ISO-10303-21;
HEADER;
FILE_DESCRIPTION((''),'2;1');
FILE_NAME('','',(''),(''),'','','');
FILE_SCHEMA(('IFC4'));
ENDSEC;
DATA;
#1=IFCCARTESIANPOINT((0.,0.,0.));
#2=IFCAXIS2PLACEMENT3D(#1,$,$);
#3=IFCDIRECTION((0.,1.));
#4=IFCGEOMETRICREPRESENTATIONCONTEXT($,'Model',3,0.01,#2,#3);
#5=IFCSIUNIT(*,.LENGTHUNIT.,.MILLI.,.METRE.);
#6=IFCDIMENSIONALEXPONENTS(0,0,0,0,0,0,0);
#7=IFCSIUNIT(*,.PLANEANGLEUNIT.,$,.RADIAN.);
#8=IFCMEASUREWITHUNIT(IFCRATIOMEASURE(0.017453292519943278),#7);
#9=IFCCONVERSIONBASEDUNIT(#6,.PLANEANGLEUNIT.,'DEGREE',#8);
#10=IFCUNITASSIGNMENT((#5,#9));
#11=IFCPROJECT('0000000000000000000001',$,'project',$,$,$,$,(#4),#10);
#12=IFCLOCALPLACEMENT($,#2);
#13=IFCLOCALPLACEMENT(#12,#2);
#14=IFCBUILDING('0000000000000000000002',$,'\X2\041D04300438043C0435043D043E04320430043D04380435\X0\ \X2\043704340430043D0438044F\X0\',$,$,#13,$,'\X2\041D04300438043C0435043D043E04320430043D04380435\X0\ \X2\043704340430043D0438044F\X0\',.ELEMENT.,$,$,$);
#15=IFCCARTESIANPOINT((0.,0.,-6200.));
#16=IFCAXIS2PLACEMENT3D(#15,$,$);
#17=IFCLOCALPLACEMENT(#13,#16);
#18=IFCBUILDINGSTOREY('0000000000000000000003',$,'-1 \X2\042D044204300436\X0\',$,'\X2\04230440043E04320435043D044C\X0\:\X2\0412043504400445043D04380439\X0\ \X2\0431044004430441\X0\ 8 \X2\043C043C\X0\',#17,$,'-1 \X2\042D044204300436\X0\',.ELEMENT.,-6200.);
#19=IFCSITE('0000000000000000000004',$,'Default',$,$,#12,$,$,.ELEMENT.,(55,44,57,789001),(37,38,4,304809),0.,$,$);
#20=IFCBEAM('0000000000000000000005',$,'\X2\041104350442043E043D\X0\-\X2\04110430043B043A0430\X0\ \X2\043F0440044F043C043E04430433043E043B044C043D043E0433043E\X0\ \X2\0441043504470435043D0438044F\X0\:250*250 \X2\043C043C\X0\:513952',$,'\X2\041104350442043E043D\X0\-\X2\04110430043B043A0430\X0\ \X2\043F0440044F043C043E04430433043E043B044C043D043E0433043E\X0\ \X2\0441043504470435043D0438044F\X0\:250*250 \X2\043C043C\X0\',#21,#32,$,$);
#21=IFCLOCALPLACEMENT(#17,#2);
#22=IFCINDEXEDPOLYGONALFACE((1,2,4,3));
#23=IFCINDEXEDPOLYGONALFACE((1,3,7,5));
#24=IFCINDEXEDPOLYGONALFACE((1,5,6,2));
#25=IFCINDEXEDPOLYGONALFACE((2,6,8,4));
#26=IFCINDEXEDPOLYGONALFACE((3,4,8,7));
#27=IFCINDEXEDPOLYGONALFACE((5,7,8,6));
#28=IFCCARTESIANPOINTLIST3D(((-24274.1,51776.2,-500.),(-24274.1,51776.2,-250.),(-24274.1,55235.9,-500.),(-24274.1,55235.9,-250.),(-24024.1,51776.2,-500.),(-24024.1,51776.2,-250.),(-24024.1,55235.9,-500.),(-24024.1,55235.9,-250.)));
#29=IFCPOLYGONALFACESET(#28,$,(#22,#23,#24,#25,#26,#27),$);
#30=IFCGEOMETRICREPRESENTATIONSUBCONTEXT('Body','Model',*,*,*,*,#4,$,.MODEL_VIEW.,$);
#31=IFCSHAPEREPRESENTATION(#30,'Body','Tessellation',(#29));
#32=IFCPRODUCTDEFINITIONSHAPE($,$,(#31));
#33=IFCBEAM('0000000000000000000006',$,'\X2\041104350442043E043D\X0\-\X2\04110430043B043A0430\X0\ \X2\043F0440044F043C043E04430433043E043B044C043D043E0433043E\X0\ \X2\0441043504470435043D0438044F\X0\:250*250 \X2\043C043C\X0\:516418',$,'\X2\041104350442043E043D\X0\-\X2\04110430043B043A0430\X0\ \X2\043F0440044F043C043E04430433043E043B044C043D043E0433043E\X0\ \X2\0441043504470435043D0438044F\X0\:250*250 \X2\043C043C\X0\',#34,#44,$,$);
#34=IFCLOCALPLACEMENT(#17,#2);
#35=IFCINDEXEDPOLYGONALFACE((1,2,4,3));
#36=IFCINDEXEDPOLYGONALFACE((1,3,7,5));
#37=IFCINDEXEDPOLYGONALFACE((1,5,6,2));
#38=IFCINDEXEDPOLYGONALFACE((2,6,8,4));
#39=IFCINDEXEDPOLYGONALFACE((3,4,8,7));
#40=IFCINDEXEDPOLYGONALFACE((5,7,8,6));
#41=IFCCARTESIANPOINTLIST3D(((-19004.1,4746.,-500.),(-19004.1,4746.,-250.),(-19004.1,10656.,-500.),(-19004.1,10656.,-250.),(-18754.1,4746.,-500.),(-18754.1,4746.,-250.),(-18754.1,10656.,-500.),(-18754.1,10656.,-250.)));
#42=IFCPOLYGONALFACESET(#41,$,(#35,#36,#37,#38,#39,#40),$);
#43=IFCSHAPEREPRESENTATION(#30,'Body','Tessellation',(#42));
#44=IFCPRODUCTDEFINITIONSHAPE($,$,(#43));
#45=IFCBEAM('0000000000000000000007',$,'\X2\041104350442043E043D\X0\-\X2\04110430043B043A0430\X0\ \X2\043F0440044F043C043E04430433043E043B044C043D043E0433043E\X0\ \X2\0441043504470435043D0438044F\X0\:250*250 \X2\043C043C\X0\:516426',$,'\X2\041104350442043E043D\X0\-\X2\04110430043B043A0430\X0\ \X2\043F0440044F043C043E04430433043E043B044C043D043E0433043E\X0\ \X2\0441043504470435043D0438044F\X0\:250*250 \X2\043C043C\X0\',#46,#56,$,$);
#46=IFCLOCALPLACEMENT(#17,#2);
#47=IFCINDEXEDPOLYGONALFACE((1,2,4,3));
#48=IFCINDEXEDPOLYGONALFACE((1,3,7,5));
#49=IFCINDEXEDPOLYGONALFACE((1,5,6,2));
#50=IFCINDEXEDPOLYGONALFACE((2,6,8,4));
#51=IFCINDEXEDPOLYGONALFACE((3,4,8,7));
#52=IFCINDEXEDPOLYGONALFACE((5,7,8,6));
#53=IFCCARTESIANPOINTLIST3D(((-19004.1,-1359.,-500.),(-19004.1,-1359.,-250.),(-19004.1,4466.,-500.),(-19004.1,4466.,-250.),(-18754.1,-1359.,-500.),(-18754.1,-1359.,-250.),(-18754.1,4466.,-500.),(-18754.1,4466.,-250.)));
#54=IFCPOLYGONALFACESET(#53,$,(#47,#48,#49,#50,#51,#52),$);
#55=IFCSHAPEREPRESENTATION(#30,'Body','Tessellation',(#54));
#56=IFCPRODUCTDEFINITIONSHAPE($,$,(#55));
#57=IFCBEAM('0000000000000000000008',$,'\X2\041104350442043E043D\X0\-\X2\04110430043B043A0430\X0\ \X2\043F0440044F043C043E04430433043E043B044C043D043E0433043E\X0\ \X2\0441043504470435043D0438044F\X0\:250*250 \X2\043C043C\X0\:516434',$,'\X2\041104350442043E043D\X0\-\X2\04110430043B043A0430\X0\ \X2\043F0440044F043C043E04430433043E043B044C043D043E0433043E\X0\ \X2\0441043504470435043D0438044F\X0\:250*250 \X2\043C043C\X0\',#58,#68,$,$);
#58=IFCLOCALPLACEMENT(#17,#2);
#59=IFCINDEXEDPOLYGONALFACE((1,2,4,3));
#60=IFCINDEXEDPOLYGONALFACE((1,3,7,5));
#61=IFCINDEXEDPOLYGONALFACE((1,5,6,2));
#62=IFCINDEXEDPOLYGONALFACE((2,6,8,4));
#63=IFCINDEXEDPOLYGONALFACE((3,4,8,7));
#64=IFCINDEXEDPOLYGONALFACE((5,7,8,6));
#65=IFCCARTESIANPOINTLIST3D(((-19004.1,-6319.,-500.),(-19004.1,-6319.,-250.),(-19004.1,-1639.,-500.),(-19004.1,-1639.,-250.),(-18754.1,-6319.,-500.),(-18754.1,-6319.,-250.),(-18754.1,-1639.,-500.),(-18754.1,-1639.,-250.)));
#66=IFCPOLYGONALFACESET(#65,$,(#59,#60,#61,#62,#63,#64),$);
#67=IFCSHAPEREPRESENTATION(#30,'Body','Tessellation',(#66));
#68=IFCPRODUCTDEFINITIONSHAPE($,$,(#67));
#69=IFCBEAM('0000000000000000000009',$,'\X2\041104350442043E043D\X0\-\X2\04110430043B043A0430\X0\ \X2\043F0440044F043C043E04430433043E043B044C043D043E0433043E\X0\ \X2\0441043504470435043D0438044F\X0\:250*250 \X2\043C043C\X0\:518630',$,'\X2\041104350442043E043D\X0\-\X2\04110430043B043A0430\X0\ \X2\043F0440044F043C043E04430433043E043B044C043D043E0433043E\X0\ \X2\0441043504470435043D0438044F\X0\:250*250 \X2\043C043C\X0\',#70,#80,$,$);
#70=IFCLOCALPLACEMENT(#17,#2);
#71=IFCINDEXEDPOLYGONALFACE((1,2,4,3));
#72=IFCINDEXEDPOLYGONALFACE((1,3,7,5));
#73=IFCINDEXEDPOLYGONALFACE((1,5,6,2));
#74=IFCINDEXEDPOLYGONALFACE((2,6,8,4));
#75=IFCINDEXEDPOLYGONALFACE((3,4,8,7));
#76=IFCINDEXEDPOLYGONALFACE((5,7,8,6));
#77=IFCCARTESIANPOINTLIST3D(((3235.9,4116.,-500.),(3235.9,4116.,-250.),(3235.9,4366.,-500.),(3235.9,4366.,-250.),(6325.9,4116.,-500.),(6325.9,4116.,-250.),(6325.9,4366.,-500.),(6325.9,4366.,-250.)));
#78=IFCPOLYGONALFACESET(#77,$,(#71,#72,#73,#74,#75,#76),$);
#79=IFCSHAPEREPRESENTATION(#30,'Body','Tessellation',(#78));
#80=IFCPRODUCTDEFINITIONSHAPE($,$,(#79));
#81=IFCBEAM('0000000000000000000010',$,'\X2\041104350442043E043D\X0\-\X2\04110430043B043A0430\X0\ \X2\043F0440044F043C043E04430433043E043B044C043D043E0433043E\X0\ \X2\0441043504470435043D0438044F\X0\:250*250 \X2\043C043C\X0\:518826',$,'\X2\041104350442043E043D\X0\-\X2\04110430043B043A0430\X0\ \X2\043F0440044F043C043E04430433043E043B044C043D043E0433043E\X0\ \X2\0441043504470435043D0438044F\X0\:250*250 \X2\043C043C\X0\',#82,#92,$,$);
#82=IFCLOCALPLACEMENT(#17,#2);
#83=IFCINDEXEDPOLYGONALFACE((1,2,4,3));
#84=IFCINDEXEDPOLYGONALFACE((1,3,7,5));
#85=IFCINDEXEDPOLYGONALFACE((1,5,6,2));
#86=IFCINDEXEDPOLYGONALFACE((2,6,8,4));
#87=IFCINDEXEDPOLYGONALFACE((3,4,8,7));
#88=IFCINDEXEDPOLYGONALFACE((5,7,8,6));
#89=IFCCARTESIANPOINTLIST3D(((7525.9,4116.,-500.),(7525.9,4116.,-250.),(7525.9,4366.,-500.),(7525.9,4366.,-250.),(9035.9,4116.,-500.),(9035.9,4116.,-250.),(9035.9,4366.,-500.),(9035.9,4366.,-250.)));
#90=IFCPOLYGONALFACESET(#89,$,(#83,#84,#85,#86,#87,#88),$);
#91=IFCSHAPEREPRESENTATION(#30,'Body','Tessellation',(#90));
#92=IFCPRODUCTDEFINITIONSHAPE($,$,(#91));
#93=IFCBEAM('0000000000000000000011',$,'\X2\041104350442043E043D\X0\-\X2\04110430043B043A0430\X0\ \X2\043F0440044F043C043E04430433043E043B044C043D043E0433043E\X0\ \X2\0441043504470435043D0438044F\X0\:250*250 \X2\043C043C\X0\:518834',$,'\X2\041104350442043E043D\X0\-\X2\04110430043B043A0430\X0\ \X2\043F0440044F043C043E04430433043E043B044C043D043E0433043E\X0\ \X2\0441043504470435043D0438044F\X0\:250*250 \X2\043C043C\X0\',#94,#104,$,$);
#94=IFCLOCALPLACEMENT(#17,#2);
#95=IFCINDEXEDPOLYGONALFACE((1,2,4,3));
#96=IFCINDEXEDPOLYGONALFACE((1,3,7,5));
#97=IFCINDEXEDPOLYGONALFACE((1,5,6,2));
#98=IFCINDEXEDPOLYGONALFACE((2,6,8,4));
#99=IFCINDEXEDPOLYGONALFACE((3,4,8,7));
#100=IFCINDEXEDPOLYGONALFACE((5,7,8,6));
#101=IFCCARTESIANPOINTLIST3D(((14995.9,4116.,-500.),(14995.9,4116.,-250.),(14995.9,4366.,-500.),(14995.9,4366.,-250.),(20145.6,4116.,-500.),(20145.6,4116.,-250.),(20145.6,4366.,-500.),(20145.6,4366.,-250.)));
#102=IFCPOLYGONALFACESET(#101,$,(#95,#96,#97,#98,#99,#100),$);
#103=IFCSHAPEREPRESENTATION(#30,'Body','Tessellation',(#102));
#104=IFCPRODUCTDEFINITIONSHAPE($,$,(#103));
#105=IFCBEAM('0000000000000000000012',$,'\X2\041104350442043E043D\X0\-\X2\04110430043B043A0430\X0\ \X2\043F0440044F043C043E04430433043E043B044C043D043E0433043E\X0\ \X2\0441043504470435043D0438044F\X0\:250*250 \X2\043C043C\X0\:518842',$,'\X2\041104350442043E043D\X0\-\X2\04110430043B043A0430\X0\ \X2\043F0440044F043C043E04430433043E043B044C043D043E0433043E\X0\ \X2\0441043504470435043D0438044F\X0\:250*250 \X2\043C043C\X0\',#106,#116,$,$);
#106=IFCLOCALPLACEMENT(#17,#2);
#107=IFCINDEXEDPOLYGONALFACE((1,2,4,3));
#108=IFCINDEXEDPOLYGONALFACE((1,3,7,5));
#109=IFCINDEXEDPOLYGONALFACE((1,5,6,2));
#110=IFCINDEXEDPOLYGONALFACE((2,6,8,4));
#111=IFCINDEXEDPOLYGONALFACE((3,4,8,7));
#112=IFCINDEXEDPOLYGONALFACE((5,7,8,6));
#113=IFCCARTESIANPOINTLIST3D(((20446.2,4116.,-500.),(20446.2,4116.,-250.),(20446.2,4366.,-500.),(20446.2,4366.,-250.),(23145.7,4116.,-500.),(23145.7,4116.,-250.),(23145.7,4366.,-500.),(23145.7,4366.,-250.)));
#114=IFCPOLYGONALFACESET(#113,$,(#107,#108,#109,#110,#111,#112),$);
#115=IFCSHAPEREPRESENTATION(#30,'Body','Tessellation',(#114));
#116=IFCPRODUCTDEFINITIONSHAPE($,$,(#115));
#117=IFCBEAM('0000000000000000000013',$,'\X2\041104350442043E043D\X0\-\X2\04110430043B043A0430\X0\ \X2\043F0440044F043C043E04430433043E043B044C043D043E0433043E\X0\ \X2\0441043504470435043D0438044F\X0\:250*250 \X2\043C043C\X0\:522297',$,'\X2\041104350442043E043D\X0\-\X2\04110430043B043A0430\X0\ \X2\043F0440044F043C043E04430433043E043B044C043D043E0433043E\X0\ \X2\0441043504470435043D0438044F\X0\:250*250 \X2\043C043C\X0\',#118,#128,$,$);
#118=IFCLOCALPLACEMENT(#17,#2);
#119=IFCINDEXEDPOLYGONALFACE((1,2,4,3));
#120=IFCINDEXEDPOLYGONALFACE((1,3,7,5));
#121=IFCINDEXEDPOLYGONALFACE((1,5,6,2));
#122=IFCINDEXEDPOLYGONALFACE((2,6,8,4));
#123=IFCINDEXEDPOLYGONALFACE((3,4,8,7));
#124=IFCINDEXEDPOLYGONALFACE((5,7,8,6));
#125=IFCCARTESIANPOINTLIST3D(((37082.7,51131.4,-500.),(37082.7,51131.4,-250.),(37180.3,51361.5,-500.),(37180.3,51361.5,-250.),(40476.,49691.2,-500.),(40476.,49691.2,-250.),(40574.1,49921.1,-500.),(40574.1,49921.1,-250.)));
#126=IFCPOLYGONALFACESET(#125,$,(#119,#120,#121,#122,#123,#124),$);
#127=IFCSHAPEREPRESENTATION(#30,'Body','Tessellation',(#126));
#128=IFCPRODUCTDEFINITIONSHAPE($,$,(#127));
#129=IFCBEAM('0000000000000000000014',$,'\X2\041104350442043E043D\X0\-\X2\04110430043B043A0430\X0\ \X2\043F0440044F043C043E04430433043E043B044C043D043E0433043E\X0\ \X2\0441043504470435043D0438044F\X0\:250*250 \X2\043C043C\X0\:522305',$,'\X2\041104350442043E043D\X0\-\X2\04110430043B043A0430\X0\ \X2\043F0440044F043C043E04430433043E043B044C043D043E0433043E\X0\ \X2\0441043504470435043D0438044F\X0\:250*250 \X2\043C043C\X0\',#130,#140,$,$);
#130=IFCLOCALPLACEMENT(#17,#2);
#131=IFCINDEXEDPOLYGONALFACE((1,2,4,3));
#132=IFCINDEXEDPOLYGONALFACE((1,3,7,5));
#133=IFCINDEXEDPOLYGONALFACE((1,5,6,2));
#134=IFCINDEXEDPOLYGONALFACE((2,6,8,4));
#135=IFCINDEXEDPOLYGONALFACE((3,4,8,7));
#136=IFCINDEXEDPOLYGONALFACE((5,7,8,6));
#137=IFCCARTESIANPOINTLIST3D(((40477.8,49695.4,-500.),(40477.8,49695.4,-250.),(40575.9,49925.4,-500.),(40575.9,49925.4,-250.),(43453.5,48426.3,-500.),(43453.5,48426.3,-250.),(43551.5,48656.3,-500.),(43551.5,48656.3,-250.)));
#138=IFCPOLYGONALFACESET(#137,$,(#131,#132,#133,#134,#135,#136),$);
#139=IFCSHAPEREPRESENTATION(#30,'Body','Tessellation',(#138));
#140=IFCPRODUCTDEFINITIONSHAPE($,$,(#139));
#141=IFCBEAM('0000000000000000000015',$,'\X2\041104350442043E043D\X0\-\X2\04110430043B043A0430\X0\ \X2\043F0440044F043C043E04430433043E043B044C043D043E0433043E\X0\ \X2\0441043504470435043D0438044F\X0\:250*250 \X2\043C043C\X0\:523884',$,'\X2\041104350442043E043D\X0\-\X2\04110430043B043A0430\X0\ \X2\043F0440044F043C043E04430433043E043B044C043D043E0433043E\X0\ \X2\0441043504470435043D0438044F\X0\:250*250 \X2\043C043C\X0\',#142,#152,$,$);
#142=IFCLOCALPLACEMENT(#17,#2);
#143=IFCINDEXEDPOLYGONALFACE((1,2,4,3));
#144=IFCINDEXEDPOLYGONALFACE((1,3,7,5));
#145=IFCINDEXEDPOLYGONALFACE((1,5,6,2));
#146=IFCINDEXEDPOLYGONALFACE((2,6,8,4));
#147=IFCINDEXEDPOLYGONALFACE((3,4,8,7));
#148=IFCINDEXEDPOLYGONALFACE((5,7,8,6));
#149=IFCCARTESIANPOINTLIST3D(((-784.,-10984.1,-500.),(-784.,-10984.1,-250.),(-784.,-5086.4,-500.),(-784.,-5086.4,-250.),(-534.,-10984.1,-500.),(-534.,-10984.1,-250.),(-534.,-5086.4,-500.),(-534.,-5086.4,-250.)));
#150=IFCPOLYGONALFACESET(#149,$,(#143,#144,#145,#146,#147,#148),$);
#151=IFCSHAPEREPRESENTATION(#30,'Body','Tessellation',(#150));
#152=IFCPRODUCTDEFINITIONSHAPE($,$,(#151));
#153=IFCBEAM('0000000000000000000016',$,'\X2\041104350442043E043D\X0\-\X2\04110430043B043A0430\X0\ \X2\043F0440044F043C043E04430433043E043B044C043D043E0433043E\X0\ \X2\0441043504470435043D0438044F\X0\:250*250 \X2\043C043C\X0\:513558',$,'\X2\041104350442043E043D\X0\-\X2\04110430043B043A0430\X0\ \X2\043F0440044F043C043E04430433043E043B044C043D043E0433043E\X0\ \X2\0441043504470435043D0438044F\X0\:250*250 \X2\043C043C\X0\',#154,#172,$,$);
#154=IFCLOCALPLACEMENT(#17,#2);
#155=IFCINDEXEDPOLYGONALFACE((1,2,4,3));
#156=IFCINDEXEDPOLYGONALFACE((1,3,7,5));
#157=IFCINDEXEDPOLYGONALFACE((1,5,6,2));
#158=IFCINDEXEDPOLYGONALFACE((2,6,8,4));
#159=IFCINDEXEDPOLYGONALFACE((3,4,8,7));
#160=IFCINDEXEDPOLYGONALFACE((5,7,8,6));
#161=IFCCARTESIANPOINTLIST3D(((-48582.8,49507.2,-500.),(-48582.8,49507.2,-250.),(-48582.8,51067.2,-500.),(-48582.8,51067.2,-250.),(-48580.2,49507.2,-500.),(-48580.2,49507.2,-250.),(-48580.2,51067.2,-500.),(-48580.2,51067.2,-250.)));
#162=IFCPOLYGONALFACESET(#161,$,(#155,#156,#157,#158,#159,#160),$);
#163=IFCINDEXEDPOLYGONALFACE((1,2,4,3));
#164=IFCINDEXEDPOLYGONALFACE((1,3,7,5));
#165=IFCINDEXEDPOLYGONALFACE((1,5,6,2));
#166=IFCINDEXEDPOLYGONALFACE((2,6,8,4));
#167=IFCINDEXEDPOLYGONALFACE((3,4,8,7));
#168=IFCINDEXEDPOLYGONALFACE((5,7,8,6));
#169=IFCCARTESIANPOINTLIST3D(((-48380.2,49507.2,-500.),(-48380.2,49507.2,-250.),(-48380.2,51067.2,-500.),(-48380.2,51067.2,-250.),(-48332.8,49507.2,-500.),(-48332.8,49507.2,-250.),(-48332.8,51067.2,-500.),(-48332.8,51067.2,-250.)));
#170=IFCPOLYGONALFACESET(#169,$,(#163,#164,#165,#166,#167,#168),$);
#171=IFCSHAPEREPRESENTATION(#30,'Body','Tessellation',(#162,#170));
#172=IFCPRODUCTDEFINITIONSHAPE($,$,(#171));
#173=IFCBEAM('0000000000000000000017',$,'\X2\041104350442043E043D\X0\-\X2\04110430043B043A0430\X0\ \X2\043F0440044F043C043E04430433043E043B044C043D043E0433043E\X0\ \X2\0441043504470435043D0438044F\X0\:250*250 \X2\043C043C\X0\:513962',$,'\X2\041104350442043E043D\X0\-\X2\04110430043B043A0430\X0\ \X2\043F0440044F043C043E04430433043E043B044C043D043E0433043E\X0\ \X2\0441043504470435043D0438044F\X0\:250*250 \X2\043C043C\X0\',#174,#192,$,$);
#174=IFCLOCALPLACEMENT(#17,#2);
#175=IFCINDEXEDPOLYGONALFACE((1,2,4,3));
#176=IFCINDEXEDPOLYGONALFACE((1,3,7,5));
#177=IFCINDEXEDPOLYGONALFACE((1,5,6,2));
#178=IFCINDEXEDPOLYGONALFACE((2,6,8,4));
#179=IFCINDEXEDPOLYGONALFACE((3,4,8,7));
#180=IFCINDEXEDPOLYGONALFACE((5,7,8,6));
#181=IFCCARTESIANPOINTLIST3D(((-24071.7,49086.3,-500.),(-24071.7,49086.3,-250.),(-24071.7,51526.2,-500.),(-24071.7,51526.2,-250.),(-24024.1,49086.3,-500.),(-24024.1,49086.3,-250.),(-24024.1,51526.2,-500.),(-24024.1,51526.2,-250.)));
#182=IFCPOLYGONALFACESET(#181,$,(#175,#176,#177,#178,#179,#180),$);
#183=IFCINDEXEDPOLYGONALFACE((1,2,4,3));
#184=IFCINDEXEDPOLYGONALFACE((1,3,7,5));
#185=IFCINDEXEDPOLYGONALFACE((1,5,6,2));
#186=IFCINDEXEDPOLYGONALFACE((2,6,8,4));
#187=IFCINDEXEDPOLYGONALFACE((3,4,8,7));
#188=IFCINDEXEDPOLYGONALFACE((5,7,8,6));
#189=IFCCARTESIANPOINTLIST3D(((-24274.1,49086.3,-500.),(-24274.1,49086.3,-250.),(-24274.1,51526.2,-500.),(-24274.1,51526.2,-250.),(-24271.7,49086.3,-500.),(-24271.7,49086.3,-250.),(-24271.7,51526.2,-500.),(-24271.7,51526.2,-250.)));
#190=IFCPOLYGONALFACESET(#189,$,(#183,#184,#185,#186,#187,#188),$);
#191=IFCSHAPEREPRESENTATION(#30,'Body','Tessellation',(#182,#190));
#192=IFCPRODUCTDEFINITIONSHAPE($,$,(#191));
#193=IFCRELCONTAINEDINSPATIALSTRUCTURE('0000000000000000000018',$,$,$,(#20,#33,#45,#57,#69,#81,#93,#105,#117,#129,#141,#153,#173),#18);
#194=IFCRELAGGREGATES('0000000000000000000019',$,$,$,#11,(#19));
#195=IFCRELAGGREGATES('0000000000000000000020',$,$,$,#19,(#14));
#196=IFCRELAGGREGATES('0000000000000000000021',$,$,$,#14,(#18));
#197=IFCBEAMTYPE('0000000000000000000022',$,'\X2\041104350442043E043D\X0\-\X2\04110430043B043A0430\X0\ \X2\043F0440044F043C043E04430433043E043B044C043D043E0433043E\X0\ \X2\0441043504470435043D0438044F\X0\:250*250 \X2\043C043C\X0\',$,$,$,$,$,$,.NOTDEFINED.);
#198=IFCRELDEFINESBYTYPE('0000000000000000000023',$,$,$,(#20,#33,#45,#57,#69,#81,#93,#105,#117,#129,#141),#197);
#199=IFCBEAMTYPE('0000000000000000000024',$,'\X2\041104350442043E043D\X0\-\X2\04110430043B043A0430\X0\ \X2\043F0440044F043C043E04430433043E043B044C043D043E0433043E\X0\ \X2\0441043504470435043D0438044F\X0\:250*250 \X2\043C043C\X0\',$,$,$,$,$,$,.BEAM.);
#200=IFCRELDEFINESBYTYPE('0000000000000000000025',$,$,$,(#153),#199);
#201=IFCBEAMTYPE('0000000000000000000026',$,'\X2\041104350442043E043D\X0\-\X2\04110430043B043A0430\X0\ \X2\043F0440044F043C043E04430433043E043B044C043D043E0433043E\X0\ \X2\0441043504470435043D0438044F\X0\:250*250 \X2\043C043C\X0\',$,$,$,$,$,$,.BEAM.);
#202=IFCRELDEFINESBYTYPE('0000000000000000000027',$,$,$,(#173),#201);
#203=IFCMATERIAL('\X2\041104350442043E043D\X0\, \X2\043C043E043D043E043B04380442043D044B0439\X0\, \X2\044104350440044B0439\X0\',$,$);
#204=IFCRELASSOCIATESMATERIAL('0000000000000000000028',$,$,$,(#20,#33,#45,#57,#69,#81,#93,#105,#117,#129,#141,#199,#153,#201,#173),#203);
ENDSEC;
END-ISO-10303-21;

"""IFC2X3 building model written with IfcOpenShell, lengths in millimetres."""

from ifc_helpers import new_model, entity, si_unit, converted_unit, direction, frame, frame_2d, origin, origin_2d_with_axis, place, context, subcontext, project, spatial, rectangle, extrude, clip, halfspace, source, transform, mapped, material, type_object, type_shapes, element, save


model = new_model("IFC2X3")

# Units and contexts
model_context = context("Model", 3, precision=0.01, world=origin(), true_north=direction((0.0, 1.0)))
body_context = subcontext(model_context, "Body", "Model", "MODEL_VIEW")
ifc_project = project(units=[si_unit("LENGTHUNIT", "METRE", prefix="MILLI"), converted_unit("PLANEANGLEUNIT", "DEGREE", entity("IfcRatioMeasure", 0.017453292519943278), si_unit("PLANEANGLEUNIT", "RADIAN"), dimensions=[0, 0, 0, 0, 0, 0, 0])], contexts=[model_context])

# Site, building, storey
site_placement = place(None, origin())
site = spatial("IfcSite", under=ifc_project, at=site_placement, Name="Default", CompositionType="ELEMENT", RefLatitude=(55, 44, 57, 789001), RefLongitude=(37, 38, 4, 304809), RefElevation=0.0)
building_placement = place(site_placement, origin())
building = spatial("IfcBuilding", under=site, at=building_placement, Name="Наименование здания", LongName="Наименование здания", CompositionType="ELEMENT")
storey_placement = place(building_placement, frame((0.0, 0.0, -6200.0)))
storey = spatial("IfcBuildingStorey", under=building, at=storey_placement, Name="-1 Этаж", ObjectType="Уровень:Верхний брус 8 мм", LongName="-1 Этаж", CompositionType="ELEMENT", Elevation=-6200.0)

# Beams
ifc_material_1 = material(Name="Бетон, монолитный, серый")
beam_type_1 = type_object("IfcBeamType", Name="Бетон-Балка прямоугольного сечения:250*250 мм", PredefinedType="NOTDEFINED")
beam_1_placement = place(storey_placement, frame((-24274.1, 51651.2, 0.0), z_axis=(0.0, 0.0, 1.0), x_axis=(0.0, 1.0, 0.0)))
element("IfcBeam", 1, at=beam_1_placement, inside=storey, type_object=beam_type_1, material=ifc_material_1, Name="Бетон-Балка прямоугольного сечения:250*250 мм:513952", ObjectType="Бетон-Балка прямоугольного сечения:250*250 мм", context=body_context, shape_type="SweptSolid", body=[
    extrude(rectangle(XDim=250.0, YDim=250.0, at=origin_2d_with_axis()), frame((125.0, -125.0, -375.0), z_axis=(1.0, 0.0, 0.0), x_axis=(0.0, 0.0, -1.0)), (0.0, 0.0, 1.0), 3459.7),
])
beam_2_placement = place(storey_placement, frame((-18754.1, 10796.0, 0.0), z_axis=(0.0, 0.0, 1.0), x_axis=(0.0, -1.0, 0.0)))
element("IfcBeam", 2, at=beam_2_placement, inside=storey, type_object=beam_type_1, material=ifc_material_1, Name="Бетон-Балка прямоугольного сечения:250*250 мм:516418", ObjectType="Бетон-Балка прямоугольного сечения:250*250 мм", context=body_context, shape_type="SweptSolid", body=[
    extrude(rectangle(XDim=250.0, YDim=250.0, at=frame_2d((0.0, 0.0), x_axis=(1.0, 0.0))), frame((140.0, -125.0, -375.0), z_axis=(1.0, 0.0, 0.0), x_axis=(0.0, 0.0, -1.0)), (0.0, 0.0, 1.0), 5910.0),
])
beam_3_placement = place(storey_placement, frame((-18754.1, 4606.0, 0.0), z_axis=(0.0, 0.0, 1.0), x_axis=(0.0, -1.0, 0.0)))
element("IfcBeam", 3, at=beam_3_placement, inside=storey, type_object=beam_type_1, material=ifc_material_1, Name="Бетон-Балка прямоугольного сечения:250*250 мм:516426", ObjectType="Бетон-Балка прямоугольного сечения:250*250 мм", context=body_context, shape_type="SweptSolid", body=[
    extrude(rectangle(XDim=250.0, YDim=250.0, at=frame_2d((0.0, 0.0), x_axis=(1.0, 0.0))), frame((140.0, -125.0, -375.0), z_axis=(1.0, 0.0, 0.0), x_axis=(0.0, 0.0, -1.0)), (0.0, 0.0, 1.0), 5825.0),
])
beam_4_placement = place(storey_placement, frame((-18754.1, -1499.0, 0.0), z_axis=(0.0, 0.0, 1.0), x_axis=(0.0, -1.0, 0.0)))
element("IfcBeam", 4, at=beam_4_placement, inside=storey, type_object=beam_type_1, material=ifc_material_1, Name="Бетон-Балка прямоугольного сечения:250*250 мм:516434", ObjectType="Бетон-Балка прямоугольного сечения:250*250 мм", context=body_context, shape_type="SweptSolid", body=[
    extrude(rectangle(XDim=250.0, YDim=250.0, at=origin_2d_with_axis()), frame((140.0, -125.0, -375.0), z_axis=(1.0, 0.0, 0.0), x_axis=(0.0, 0.0, -1.0)), (0.0, 0.0, 1.0), 4680.0),
])
beam_5_placement = place(storey_placement, frame((3235.9, 4366.0, 0.0)))
element("IfcBeam", 5, at=beam_5_placement, inside=storey, type_object=beam_type_1, material=ifc_material_1, Name="Бетон-Балка прямоугольного сечения:250*250 мм:518630", ObjectType="Бетон-Балка прямоугольного сечения:250*250 мм", context=body_context, shape_type="SweptSolid", body=[
    extrude(rectangle(XDim=250.0, YDim=250.0, at=origin_2d_with_axis()), frame((0.0, -125.0, -375.0), z_axis=(1.0, 0.0, 0.0), x_axis=(0.0, 0.0, -1.0)), (0.0, 0.0, 1.0), 3090.0),
])
beam_6_placement = place(storey_placement, frame((7525.9, 4366.0, 0.0)))
element("IfcBeam", 6, at=beam_6_placement, inside=storey, type_object=beam_type_1, material=ifc_material_1, Name="Бетон-Балка прямоугольного сечения:250*250 мм:518826", ObjectType="Бетон-Балка прямоугольного сечения:250*250 мм", context=body_context, shape_type="SweptSolid", body=[
    extrude(rectangle(XDim=250.0, YDim=250.0, at=origin_2d_with_axis()), frame((0.0, -125.0, -375.0), z_axis=(1.0, 0.0, 0.0), x_axis=(0.0, 0.0, -1.0)), (0.0, 0.0, 1.0), 1510.0),
])
beam_7_placement = place(storey_placement, frame((14981.3, 4366.0, 0.0)))
element("IfcBeam", 7, at=beam_7_placement, inside=storey, type_object=beam_type_1, material=ifc_material_1, Name="Бетон-Балка прямоугольного сечения:250*250 мм:518834", ObjectType="Бетон-Балка прямоугольного сечения:250*250 мм", context=body_context, shape_type="SweptSolid", body=[
    extrude(rectangle(XDim=250.0, YDim=250.0, at=origin_2d_with_axis()), frame((14.5, -125.0, -375.0), z_axis=(1.0, 0.0, 0.0), x_axis=(0.0, 0.0, -1.0)), (0.0, 0.0, 1.0), 5149.8),
])
beam_8_placement = place(storey_placement, frame((20446.2, 4366.0, 0.0)))
element("IfcBeam", 8, at=beam_8_placement, inside=storey, type_object=beam_type_1, material=ifc_material_1, Name="Бетон-Балка прямоугольного сечения:250*250 мм:518842", ObjectType="Бетон-Балка прямоугольного сечения:250*250 мм", context=body_context, shape_type="SweptSolid", body=[
    extrude(rectangle(XDim=250.0, YDim=250.0, at=origin_2d_with_axis()), frame((0.0, -125.0, -375.0), z_axis=(1.0, 0.0, 0.0), x_axis=(0.0, 0.0, -1.0)), (0.0, 0.0, 1.0), 2699.5),
])
beam_9_placement = place(storey_placement, frame((37180.3, 51361.5, 0.0), z_axis=(0.0, 0.0, 1.0), x_axis=(0.920522, -0.390691, 0.0)))
element("IfcBeam", 9, at=beam_9_placement, inside=storey, type_object=beam_type_1, material=ifc_material_1, Name="Бетон-Балка прямоугольного сечения:250*250 мм:522297", ObjectType="Бетон-Балка прямоугольного сечения:250*250 мм", context=body_context, shape_type="SweptSolid", body=[
    clip(extrude(rectangle(XDim=250.0, YDim=250.0, at=frame_2d((0.0, 0.0), x_axis=(1.0, 0.0))), frame((0.0, -125.0, -375.0), z_axis=(1.0, 0.0, 0.0), x_axis=(0.0, 0.0, -1.0)), (0.0, 0.0, 1.0), 3686.7), halfspace(frame((3686.3, -274.1, -21.4), z_axis=(0.999998, -0.001749, 0.0), x_axis=(0.001749, 0.999998, 0.0)), False)),
])
beam_10_placement = place(storey_placement, frame((40460.9, 49974.4, 0.0), z_axis=(0.0, 0.0, 1.0), x_axis=(0.919837, -0.3923, 0.0)))
element("IfcBeam", 10, at=beam_10_placement, inside=storey, type_object=beam_type_1, material=ifc_material_1, Name="Бетон-Балка прямоугольного сечения:250*250 мм:522305", ObjectType="Бетон-Балка прямоугольного сечения:250*250 мм", context=body_context, shape_type="SweptSolid", body=[
    extrude(rectangle(XDim=250.0, YDim=250.0, at=frame_2d((0.0, 0.0), x_axis=(1.0, 0.0))), frame((125.0, -125.0, -375.0), z_axis=(1.0, 0.0, 0.0), x_axis=(0.0, 0.0, -1.0)), (0.0, 0.0, 1.0), 3235.0),
])
beam_11_placement = place(storey_placement, frame((-534.0, -5286.4, 0.0), z_axis=(0.0, 0.0, 1.0), x_axis=(0.0, -1.0, 0.0)))
element("IfcBeam", 11, at=beam_11_placement, inside=storey, type_object=beam_type_1, material=ifc_material_1, Name="Бетон-Балка прямоугольного сечения:250*250 мм:523884", ObjectType="Бетон-Балка прямоугольного сечения:250*250 мм", context=body_context, shape_type="SweptSolid", body=[
    extrude(rectangle(XDim=250.0, YDim=250.0, at=origin_2d_with_axis()), frame((-200.0, -125.0, -375.0), z_axis=(1.0, 0.0, 0.0), x_axis=(0.0, 0.0, -1.0)), (0.0, 0.0, 1.0), 5897.7),
])
beam_type_2 = type_object("IfcBeamType", Name="Бетон-Балка прямоугольного сечения:250*250 мм", PredefinedType="BEAM", material=ifc_material_1)
shared_shape_1 = source(origin(), body_context, "Body", "SweptSolid", [
    extrude(rectangle(XDim=250.0, YDim=2.5, at=frame_2d((0.0, 0.0), x_axis=(0.0, 1.0))), frame((-48581.5, 49507.2, -6575.0), z_axis=(0.0, 1.0, 0.0), x_axis=(-1.0, 0.0, 0.0)), (0.0, 0.0, 1.0), 1560.0),
    extrude(rectangle(XDim=250.0, YDim=47.5, at=frame_2d((0.0, 0.0), x_axis=(0.0, 1.0))), frame((-48356.5, 49507.2, -6575.0), z_axis=(0.0, 1.0, 0.0), x_axis=(-1.0, 0.0, 0.0)), (0.0, 0.0, 1.0), 1560.0),
])
type_shapes(beam_type_2, [shared_shape_1])
beam_12_placement = place(storey_placement, frame((0.0, 0.0, 6200.0)))
element("IfcBeam", 12, at=beam_12_placement, inside=storey, type_object=beam_type_2, material=ifc_material_1, Name="Бетон-Балка прямоугольного сечения:250*250 мм:513558", ObjectType="Бетон-Балка прямоугольного сечения:250*250 мм", context=body_context, shape_type="MappedRepresentation", body=[
    mapped(shared_shape_1, transform((0.0, 0.0, 0.0), scale=1.0)),
])
beam_type_3 = type_object("IfcBeamType", Name="Бетон-Балка прямоугольного сечения:250*250 мм", PredefinedType="BEAM", material=ifc_material_1)
shared_shape_2 = source(origin(), body_context, "Body", "SweptSolid", [
    extrude(rectangle(XDim=250.0, YDim=47.7, at=frame_2d((0.0, 0.0), x_axis=(0.0, 1.0))), frame((-24047.9, 49086.3, -6575.0), z_axis=(0.0, 1.0, 0.0), x_axis=(-1.0, 0.0, 0.0)), (0.0, 0.0, 1.0), 2439.9),
    extrude(rectangle(XDim=250.0, YDim=2.3, at=frame_2d((0.0, 0.0), x_axis=(0.0, 1.0))), frame((-24272.9, 49086.3, -6575.0), z_axis=(0.0, 1.0, 0.0), x_axis=(-1.0, 0.0, 0.0)), (0.0, 0.0, 1.0), 2439.9),
])
type_shapes(beam_type_3, [shared_shape_2])
beam_13_placement = place(storey_placement, frame((0.0, 0.0, 6200.0)))
element("IfcBeam", 13, at=beam_13_placement, inside=storey, type_object=beam_type_3, material=ifc_material_1, Name="Бетон-Балка прямоугольного сечения:250*250 мм:513962", ObjectType="Бетон-Балка прямоугольного сечения:250*250 мм", context=body_context, shape_type="MappedRepresentation", body=[
    mapped(shared_shape_2, transform((0.0, 0.0, 0.0), scale=1.0)),
])

save(model, "model.ifc")
